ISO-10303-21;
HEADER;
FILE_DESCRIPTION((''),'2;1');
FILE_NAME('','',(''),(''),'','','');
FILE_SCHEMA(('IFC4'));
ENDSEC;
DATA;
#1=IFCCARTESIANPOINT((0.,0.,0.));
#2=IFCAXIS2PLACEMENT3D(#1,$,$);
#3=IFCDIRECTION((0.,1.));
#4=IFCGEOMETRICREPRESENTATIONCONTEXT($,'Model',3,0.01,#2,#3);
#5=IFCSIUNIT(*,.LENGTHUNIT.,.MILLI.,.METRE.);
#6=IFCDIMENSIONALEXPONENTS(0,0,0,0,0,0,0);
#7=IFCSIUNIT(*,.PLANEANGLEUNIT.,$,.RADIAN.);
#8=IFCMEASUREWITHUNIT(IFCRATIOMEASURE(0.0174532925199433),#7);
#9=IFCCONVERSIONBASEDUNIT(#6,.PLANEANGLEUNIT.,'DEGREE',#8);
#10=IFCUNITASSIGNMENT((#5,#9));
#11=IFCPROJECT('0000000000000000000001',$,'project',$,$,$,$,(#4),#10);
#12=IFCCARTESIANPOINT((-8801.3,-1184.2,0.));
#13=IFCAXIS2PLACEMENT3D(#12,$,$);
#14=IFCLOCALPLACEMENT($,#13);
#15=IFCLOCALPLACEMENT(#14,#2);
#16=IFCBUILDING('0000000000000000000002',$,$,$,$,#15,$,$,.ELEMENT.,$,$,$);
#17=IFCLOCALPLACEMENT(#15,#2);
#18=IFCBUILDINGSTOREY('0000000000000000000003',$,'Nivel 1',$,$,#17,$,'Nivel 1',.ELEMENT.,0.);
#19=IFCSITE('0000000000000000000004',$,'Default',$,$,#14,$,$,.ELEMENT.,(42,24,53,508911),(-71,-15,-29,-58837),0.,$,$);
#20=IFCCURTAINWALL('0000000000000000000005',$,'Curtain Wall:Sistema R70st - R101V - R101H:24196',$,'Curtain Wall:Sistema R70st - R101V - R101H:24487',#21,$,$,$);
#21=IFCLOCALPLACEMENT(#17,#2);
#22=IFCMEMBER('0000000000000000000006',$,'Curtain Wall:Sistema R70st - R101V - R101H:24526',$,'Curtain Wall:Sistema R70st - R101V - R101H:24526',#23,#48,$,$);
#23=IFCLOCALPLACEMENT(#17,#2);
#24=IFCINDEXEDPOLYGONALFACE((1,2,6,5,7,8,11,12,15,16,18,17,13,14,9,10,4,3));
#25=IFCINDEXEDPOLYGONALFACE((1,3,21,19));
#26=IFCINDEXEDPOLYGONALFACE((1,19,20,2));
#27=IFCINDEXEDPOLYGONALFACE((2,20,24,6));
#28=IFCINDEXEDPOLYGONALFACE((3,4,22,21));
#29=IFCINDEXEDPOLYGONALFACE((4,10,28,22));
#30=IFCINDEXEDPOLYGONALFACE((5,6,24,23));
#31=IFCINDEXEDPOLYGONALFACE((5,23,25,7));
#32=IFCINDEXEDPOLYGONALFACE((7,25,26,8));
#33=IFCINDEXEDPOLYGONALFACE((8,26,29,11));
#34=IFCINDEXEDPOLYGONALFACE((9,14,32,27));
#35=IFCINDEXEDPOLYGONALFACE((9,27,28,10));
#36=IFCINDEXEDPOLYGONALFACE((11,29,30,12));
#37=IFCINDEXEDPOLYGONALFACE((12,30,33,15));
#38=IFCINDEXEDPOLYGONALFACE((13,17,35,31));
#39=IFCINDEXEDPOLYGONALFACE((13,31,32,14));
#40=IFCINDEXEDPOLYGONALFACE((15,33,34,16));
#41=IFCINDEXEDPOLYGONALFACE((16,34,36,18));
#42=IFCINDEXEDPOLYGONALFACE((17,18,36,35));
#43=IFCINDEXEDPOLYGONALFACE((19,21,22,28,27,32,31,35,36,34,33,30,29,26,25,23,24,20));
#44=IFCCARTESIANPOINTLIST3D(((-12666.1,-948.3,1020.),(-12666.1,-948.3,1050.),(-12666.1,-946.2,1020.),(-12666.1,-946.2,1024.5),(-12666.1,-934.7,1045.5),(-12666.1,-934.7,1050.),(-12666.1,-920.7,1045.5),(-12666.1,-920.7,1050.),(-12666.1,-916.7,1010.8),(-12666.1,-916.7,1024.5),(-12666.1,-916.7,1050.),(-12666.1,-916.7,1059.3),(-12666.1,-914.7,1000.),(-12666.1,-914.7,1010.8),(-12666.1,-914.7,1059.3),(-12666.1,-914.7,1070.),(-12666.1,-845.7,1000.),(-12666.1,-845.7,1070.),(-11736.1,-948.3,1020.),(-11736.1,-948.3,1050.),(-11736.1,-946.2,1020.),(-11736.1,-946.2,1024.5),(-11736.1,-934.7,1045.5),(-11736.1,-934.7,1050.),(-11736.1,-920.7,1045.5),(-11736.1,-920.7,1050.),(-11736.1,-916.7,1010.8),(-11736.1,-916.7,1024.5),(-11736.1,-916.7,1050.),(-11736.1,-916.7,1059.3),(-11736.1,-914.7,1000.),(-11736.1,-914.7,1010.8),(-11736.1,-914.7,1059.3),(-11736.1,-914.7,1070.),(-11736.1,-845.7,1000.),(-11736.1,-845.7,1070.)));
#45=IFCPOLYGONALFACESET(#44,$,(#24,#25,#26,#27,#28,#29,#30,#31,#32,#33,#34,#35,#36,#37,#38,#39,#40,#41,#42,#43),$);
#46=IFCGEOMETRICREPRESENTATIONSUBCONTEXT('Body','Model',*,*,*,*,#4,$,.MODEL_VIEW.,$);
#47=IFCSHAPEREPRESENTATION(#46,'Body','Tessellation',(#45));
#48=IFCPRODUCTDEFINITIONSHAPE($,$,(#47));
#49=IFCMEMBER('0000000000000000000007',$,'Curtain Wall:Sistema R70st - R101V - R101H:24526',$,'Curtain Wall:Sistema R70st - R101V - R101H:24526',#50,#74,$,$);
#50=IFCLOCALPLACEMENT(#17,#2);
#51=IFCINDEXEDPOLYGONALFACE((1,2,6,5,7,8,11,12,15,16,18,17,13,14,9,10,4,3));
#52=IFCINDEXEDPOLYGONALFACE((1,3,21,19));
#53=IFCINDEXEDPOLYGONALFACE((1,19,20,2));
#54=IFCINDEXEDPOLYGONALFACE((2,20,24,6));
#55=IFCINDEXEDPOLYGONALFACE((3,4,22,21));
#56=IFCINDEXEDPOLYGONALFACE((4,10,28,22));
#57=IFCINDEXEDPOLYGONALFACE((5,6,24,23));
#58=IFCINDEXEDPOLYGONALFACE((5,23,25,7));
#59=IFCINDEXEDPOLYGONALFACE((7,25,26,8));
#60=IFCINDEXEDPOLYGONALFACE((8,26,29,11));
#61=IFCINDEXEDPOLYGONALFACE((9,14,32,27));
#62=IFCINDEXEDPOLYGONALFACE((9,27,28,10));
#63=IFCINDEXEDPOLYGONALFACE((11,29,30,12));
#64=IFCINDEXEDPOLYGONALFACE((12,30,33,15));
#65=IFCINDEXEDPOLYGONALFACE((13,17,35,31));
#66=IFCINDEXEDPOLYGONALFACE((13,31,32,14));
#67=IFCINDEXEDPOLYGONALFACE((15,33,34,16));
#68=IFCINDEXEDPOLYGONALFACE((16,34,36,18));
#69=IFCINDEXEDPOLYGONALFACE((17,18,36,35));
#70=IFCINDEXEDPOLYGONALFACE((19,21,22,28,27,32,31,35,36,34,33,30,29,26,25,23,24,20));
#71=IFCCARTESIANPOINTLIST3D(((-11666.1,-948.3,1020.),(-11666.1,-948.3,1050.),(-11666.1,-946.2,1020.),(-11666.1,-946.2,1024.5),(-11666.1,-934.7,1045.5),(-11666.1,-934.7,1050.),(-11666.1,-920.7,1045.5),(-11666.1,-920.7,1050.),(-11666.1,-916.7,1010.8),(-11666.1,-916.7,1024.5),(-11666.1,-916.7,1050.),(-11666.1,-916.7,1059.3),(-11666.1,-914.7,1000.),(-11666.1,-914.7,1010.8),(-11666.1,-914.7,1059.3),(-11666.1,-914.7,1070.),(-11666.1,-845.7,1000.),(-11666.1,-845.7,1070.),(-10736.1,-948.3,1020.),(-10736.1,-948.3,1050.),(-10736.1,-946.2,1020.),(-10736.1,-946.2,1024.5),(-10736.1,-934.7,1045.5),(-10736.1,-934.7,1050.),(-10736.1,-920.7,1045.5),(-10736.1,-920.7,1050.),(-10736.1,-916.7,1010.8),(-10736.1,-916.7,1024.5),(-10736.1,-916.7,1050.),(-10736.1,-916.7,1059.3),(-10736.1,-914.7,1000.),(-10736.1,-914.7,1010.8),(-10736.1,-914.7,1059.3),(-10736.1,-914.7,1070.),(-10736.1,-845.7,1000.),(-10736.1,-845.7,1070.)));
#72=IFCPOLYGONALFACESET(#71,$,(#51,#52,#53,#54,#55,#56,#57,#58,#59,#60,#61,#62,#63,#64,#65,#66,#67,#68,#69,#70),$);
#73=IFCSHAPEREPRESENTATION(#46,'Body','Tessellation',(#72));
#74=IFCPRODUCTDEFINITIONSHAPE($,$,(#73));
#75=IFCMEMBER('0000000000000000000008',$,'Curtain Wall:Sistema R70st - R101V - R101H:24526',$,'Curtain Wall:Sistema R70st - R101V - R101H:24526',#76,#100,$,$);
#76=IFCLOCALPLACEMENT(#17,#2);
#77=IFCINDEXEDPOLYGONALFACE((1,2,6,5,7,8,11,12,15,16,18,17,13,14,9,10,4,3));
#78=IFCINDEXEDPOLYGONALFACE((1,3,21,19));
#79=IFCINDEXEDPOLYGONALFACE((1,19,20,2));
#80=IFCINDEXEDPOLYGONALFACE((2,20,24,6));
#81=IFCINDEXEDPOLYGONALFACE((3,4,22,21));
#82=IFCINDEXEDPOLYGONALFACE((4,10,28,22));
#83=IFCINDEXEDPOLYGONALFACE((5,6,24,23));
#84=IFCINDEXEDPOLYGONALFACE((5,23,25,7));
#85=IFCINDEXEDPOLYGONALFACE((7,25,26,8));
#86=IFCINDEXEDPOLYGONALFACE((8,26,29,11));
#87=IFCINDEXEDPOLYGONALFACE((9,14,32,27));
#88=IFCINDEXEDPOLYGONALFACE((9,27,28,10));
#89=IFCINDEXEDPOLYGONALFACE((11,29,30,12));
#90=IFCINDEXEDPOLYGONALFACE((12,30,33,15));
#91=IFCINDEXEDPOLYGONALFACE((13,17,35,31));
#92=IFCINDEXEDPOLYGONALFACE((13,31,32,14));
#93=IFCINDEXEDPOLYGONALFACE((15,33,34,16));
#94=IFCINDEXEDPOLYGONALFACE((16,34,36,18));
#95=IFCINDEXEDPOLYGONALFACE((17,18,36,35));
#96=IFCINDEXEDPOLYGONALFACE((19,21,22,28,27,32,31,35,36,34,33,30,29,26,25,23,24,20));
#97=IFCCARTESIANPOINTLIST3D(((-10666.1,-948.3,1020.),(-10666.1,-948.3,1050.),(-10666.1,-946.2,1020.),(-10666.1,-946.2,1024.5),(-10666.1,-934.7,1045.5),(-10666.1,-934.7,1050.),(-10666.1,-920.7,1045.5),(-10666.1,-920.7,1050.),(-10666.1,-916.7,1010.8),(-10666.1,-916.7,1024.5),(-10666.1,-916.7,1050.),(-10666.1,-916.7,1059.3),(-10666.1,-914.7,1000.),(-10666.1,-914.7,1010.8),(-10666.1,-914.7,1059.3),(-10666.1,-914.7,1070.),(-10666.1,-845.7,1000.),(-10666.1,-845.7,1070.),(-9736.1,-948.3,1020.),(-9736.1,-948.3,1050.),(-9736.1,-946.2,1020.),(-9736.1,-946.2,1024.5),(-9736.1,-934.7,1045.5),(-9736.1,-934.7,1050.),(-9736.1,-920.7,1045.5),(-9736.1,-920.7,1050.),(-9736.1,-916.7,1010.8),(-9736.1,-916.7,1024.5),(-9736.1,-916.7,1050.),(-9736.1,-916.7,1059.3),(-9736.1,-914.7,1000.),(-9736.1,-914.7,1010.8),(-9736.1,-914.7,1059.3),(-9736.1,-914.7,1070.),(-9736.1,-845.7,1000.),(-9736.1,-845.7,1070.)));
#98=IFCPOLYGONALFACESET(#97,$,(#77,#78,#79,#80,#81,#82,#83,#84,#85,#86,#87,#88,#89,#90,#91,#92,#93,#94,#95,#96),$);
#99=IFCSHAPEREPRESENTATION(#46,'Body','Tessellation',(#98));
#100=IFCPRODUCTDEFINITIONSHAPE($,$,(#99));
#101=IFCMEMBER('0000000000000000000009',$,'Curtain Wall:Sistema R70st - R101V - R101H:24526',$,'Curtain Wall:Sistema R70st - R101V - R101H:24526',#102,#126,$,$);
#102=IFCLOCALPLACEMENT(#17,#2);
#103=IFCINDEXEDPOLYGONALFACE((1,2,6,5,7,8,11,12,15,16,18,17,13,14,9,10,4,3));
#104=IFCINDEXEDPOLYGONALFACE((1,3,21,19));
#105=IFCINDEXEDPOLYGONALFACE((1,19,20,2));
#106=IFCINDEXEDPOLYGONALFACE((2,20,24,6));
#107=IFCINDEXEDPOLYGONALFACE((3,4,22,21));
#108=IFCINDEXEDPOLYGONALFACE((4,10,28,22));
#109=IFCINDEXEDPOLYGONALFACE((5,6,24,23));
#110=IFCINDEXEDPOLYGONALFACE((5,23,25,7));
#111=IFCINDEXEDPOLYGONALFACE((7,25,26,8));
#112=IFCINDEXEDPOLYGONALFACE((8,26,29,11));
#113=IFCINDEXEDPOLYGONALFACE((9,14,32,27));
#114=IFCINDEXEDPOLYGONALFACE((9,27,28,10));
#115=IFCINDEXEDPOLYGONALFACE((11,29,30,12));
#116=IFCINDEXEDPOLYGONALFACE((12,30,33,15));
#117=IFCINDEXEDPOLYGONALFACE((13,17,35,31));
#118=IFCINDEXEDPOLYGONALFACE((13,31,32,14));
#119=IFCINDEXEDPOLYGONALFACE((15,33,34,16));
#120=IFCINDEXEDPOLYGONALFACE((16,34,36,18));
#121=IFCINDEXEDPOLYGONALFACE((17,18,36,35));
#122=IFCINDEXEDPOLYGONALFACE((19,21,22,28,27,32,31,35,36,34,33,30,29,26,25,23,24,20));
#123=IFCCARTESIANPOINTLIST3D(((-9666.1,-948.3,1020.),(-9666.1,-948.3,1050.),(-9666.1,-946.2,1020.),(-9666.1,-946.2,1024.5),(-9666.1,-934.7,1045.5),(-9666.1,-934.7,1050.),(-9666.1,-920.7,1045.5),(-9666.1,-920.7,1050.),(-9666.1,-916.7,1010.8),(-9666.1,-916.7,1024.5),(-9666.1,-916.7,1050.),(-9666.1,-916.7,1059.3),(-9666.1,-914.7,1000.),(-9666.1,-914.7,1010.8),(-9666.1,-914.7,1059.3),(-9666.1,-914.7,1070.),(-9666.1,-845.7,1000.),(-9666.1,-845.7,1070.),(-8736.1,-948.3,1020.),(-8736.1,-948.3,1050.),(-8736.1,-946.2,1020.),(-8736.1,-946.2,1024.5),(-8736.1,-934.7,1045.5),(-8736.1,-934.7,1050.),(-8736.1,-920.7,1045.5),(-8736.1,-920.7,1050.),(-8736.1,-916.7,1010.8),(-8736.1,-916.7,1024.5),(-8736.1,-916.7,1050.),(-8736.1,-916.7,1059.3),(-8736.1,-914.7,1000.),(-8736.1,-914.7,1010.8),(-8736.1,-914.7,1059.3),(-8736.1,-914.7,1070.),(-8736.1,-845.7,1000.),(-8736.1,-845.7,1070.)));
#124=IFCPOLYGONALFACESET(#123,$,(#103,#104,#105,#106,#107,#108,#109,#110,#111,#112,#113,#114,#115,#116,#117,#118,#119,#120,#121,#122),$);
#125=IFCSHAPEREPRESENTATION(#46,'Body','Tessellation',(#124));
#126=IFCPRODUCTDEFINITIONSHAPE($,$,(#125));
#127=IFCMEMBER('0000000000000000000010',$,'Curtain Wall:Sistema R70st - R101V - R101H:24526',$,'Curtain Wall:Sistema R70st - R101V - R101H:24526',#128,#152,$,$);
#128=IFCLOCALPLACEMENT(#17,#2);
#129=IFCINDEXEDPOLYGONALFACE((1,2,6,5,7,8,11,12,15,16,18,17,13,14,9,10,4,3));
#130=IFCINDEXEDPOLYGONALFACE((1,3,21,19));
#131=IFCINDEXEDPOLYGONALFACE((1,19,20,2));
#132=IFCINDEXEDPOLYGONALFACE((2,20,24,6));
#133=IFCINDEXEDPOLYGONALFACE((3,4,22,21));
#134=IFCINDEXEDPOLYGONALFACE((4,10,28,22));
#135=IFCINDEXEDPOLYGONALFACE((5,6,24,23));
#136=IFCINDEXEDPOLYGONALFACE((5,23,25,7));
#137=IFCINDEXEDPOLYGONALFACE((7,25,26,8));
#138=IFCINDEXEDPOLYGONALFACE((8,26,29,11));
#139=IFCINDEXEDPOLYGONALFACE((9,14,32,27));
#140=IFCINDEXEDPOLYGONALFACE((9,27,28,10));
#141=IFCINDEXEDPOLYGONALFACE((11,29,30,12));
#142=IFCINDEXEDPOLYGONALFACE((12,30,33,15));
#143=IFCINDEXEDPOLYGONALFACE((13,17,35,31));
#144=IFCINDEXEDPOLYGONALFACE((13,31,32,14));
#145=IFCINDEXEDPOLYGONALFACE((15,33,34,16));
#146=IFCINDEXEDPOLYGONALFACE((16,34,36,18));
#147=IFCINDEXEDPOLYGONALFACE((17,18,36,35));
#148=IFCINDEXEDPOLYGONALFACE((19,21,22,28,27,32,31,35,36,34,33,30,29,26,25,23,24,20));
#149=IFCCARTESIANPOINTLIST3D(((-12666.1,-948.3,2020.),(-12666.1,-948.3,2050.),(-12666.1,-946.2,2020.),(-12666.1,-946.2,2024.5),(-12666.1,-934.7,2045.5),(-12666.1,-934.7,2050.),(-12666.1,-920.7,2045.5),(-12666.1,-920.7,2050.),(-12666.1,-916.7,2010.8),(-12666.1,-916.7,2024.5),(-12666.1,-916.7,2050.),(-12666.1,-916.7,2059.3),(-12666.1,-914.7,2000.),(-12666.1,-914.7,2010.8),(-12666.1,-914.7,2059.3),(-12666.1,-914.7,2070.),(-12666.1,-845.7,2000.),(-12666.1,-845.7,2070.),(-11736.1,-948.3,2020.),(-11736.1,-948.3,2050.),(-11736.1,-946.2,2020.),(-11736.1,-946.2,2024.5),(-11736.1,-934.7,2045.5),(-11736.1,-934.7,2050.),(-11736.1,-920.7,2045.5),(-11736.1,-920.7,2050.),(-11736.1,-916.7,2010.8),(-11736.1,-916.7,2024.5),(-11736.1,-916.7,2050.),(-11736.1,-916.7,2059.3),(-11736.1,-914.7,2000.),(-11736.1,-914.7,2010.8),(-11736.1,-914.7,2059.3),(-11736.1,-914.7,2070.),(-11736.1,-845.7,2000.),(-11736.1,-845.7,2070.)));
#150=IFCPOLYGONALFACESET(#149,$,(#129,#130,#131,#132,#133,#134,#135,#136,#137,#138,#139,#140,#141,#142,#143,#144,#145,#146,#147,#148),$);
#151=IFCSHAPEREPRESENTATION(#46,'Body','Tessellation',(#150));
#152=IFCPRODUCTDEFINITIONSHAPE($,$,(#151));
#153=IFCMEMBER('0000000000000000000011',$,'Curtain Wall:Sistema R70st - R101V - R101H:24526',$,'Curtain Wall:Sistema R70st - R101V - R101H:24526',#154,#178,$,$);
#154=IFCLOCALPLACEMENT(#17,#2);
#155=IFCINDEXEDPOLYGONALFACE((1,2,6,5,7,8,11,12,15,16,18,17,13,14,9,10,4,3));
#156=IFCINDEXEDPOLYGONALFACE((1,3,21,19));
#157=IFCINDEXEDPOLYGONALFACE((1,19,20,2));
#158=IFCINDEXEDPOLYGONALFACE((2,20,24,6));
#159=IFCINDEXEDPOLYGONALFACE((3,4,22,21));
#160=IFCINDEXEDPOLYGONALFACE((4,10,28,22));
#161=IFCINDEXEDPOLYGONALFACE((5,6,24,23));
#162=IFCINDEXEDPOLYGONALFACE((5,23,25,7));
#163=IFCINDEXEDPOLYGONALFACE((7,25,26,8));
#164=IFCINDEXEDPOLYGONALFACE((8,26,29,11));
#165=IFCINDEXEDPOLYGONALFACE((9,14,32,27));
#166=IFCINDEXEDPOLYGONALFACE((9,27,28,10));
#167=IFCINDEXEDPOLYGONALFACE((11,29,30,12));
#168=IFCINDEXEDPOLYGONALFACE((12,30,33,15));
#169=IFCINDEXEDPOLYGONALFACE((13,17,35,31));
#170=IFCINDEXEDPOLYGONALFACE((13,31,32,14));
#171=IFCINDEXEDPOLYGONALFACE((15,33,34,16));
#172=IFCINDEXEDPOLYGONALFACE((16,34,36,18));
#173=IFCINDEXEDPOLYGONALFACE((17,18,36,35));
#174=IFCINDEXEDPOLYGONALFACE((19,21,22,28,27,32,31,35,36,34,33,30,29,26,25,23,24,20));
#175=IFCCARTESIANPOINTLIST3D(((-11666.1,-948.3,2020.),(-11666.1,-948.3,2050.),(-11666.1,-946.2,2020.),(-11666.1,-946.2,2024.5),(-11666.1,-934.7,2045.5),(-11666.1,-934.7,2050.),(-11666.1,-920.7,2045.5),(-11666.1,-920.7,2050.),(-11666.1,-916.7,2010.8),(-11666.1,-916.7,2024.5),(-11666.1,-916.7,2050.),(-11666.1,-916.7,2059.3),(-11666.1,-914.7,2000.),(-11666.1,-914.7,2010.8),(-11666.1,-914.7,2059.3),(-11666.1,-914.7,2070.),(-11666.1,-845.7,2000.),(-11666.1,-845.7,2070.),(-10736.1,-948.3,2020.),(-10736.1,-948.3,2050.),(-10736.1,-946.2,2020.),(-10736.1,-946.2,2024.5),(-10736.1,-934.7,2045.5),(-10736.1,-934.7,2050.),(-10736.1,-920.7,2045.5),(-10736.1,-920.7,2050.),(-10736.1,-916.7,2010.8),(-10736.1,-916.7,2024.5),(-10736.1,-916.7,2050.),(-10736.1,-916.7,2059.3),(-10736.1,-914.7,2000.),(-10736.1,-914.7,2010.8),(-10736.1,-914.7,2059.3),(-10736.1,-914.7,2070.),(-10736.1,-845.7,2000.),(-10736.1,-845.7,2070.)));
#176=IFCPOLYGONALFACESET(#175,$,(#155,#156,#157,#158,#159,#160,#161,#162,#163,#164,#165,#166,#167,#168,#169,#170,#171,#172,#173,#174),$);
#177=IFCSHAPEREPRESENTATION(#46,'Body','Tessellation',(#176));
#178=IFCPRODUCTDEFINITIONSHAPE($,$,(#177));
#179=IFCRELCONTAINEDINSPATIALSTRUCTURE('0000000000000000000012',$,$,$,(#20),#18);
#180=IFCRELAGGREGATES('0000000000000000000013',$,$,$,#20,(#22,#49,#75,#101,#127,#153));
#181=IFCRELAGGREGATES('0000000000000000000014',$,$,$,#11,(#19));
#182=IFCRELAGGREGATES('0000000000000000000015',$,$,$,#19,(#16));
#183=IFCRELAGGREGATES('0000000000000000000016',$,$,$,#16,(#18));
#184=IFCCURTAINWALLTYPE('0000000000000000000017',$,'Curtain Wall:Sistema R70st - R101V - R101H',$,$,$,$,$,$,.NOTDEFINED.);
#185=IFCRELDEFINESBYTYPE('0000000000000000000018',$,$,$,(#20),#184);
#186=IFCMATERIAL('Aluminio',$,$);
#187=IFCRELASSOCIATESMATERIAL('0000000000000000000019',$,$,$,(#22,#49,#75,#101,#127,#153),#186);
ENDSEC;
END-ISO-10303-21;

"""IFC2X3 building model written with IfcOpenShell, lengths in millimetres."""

from ifc_helpers import new_model, entity, si_unit, converted_unit, direction, frame, origin, place, context, subcontext, project, spatial, polyline, outline, extrude, material, type_object, element, aggregate, save


model = new_model("IFC2X3")

# Units and contexts
model_context = context("Model", 3, precision=0.01, world=origin(), true_north=direction((0.0, 1.0)))
body_context = subcontext(model_context, "Body", "Model", "MODEL_VIEW")
ifc_project = project(units=[si_unit("LENGTHUNIT", "METRE", prefix="MILLI"), converted_unit("PLANEANGLEUNIT", "DEGREE", entity("IfcRatioMeasure", 0.0174532925199433), si_unit("PLANEANGLEUNIT", "RADIAN"), dimensions=[0, 0, 0, 0, 0, 0, 0])], contexts=[model_context])

# Site, building, storey
site_placement = place(None, frame((-8801.3, -1184.2, 0.0)))
site = spatial("IfcSite", under=ifc_project, at=site_placement, Name="Default", CompositionType="ELEMENT", RefLatitude=(42, 24, 53, 508911), RefLongitude=(-71, -15, -29, -58837), RefElevation=0.0)
building_placement = place(site_placement, origin())
building = spatial("IfcBuilding", under=site, at=building_placement, CompositionType="ELEMENT")
storey_placement = place(building_placement, origin())
storey = spatial("IfcBuildingStorey", under=building, at=storey_placement, Name="Nivel 1", LongName="Nivel 1", CompositionType="ELEMENT", Elevation=0.0)

# Curtain wall, members
curtain_wall_type = type_object("IfcCurtainWallType", Name="Curtain Wall:Sistema R70st - R101V - R101H", PredefinedType="NOTDEFINED")
curtain_wall_placement = place(storey_placement, origin())
curtain_wall = element("IfcCurtainWall", 1, at=curtain_wall_placement, inside=storey, type_object=curtain_wall_type, Name="Curtain Wall:Sistema R70st - R101V - R101H:24196", ObjectType="Curtain Wall:Sistema R70st - R101V - R101H:24487")
ifc_material = material(Name="Aluminio")
member_1_placement = place(curtain_wall_placement, origin())
member_1 = element("IfcMember", 2, at=member_1_placement, material=ifc_material, Name="Curtain Wall:Sistema R70st - R101V - R101H:24526", ObjectType="Curtain Wall:Sistema R70st - R101V - R101H:24526", context=body_context, shape_type="SweptSolid", body=[
    extrude(outline(polyline([(-33.3, -71.9), (36.7, -71.9), (36.7, -2.9), (25.9, -2.9), (25.9, -0.9), (12.2, -0.9), (12.2, 28.6), (16.7, 28.6), (16.7, 30.7), (-13.3, 30.7), (-13.3, 17.1), (-8.8, 17.1), (-8.8, 3.1), (-13.3, 3.1), (-13.3, -0.9), (-22.6, -0.9), (-22.6, -2.9), (-33.3, -2.9), (-33.3, -71.9)])), frame((-11736.1, -917.6, 1036.7), z_axis=(-1.0, 0.0, 0.0), x_axis=(0.0, 0.0, -1.0)), (0.0, 0.0, 1.0), 930.0),
])
member_2_placement = place(curtain_wall_placement, origin())
member_2 = element("IfcMember", 3, at=member_2_placement, material=ifc_material, Name="Curtain Wall:Sistema R70st - R101V - R101H:24526", ObjectType="Curtain Wall:Sistema R70st - R101V - R101H:24526", context=body_context, shape_type="SweptSolid", body=[
    extrude(outline(polyline([(-33.3, -71.9), (36.7, -71.9), (36.7, -2.9), (25.9, -2.9), (25.9, -0.9), (12.2, -0.9), (12.2, 28.6), (16.7, 28.6), (16.7, 30.7), (-13.3, 30.7), (-13.3, 17.1), (-8.8, 17.1), (-8.8, 3.1), (-13.3, 3.1), (-13.3, -0.9), (-22.6, -0.9), (-22.6, -2.9), (-33.3, -2.9), (-33.3, -71.9)])), frame((-10736.1, -917.6, 1036.7), z_axis=(-1.0, 0.0, 0.0), x_axis=(0.0, 0.0, -1.0)), (0.0, 0.0, 1.0), 930.0),
])
member_3_placement = place(curtain_wall_placement, origin())
member_3 = element("IfcMember", 4, at=member_3_placement, material=ifc_material, Name="Curtain Wall:Sistema R70st - R101V - R101H:24526", ObjectType="Curtain Wall:Sistema R70st - R101V - R101H:24526", context=body_context, shape_type="SweptSolid", body=[
    extrude(outline(polyline([(-33.3, -71.9), (36.7, -71.9), (36.7, -2.9), (25.9, -2.9), (25.9, -0.9), (12.2, -0.9), (12.2, 28.6), (16.7, 28.6), (16.7, 30.7), (-13.3, 30.7), (-13.3, 17.1), (-8.8, 17.1), (-8.8, 3.1), (-13.3, 3.1), (-13.3, -0.9), (-22.6, -0.9), (-22.6, -2.9), (-33.3, -2.9), (-33.3, -71.9)])), frame((-9736.1, -917.6, 1036.7), z_axis=(-1.0, 0.0, 0.0), x_axis=(0.0, 0.0, -1.0)), (0.0, 0.0, 1.0), 930.0),
])
member_4_placement = place(curtain_wall_placement, origin())
member_4 = element("IfcMember", 5, at=member_4_placement, material=ifc_material, Name="Curtain Wall:Sistema R70st - R101V - R101H:24526", ObjectType="Curtain Wall:Sistema R70st - R101V - R101H:24526", context=body_context, shape_type="SweptSolid", body=[
    extrude(outline(polyline([(-33.3, -71.9), (36.7, -71.9), (36.7, -2.9), (25.9, -2.9), (25.9, -0.9), (12.2, -0.9), (12.2, 28.6), (16.7, 28.6), (16.7, 30.7), (-13.3, 30.7), (-13.3, 17.1), (-8.8, 17.1), (-8.8, 3.1), (-13.3, 3.1), (-13.3, -0.9), (-22.6, -0.9), (-22.6, -2.9), (-33.3, -2.9), (-33.3, -71.9)])), frame((-8736.1, -917.6, 1036.7), z_axis=(-1.0, 0.0, 0.0), x_axis=(0.0, 0.0, -1.0)), (0.0, 0.0, 1.0), 930.0),
])
member_5_placement = place(curtain_wall_placement, origin())
member_5 = element("IfcMember", 6, at=member_5_placement, material=ifc_material, Name="Curtain Wall:Sistema R70st - R101V - R101H:24526", ObjectType="Curtain Wall:Sistema R70st - R101V - R101H:24526", context=body_context, shape_type="SweptSolid", body=[
    extrude(outline(polyline([(-33.3, -71.9), (36.7, -71.9), (36.7, -2.9), (25.9, -2.9), (25.9, -0.9), (12.2, -0.9), (12.2, 28.6), (16.7, 28.6), (16.7, 30.7), (-13.3, 30.7), (-13.3, 17.1), (-8.8, 17.1), (-8.8, 3.1), (-13.3, 3.1), (-13.3, -0.9), (-22.6, -0.9), (-22.6, -2.9), (-33.3, -2.9), (-33.3, -71.9)])), frame((-11736.1, -917.6, 2036.7), z_axis=(-1.0, 0.0, 0.0), x_axis=(0.0, 0.0, -1.0)), (0.0, 0.0, 1.0), 930.0),
])
member_6_placement = place(curtain_wall_placement, origin())
member_6 = element("IfcMember", 7, at=member_6_placement, material=ifc_material, Name="Curtain Wall:Sistema R70st - R101V - R101H:24526", ObjectType="Curtain Wall:Sistema R70st - R101V - R101H:24526", context=body_context, shape_type="SweptSolid", body=[
    extrude(outline(polyline([(-33.3, -71.9), (36.7, -71.9), (36.7, -2.9), (25.9, -2.9), (25.9, -0.9), (12.2, -0.9), (12.2, 28.6), (16.7, 28.6), (16.7, 30.7), (-13.3, 30.7), (-13.3, 17.1), (-8.8, 17.1), (-8.8, 3.1), (-13.3, 3.1), (-13.3, -0.9), (-22.6, -0.9), (-22.6, -2.9), (-33.3, -2.9), (-33.3, -71.9)])), frame((-10736.1, -917.6, 2036.7), z_axis=(-1.0, 0.0, 0.0), x_axis=(0.0, 0.0, -1.0)), (0.0, 0.0, 1.0), 930.0),
])
aggregate(curtain_wall, [member_1, member_2, member_3, member_4, member_5, member_6])

save(model, "model.ifc")
